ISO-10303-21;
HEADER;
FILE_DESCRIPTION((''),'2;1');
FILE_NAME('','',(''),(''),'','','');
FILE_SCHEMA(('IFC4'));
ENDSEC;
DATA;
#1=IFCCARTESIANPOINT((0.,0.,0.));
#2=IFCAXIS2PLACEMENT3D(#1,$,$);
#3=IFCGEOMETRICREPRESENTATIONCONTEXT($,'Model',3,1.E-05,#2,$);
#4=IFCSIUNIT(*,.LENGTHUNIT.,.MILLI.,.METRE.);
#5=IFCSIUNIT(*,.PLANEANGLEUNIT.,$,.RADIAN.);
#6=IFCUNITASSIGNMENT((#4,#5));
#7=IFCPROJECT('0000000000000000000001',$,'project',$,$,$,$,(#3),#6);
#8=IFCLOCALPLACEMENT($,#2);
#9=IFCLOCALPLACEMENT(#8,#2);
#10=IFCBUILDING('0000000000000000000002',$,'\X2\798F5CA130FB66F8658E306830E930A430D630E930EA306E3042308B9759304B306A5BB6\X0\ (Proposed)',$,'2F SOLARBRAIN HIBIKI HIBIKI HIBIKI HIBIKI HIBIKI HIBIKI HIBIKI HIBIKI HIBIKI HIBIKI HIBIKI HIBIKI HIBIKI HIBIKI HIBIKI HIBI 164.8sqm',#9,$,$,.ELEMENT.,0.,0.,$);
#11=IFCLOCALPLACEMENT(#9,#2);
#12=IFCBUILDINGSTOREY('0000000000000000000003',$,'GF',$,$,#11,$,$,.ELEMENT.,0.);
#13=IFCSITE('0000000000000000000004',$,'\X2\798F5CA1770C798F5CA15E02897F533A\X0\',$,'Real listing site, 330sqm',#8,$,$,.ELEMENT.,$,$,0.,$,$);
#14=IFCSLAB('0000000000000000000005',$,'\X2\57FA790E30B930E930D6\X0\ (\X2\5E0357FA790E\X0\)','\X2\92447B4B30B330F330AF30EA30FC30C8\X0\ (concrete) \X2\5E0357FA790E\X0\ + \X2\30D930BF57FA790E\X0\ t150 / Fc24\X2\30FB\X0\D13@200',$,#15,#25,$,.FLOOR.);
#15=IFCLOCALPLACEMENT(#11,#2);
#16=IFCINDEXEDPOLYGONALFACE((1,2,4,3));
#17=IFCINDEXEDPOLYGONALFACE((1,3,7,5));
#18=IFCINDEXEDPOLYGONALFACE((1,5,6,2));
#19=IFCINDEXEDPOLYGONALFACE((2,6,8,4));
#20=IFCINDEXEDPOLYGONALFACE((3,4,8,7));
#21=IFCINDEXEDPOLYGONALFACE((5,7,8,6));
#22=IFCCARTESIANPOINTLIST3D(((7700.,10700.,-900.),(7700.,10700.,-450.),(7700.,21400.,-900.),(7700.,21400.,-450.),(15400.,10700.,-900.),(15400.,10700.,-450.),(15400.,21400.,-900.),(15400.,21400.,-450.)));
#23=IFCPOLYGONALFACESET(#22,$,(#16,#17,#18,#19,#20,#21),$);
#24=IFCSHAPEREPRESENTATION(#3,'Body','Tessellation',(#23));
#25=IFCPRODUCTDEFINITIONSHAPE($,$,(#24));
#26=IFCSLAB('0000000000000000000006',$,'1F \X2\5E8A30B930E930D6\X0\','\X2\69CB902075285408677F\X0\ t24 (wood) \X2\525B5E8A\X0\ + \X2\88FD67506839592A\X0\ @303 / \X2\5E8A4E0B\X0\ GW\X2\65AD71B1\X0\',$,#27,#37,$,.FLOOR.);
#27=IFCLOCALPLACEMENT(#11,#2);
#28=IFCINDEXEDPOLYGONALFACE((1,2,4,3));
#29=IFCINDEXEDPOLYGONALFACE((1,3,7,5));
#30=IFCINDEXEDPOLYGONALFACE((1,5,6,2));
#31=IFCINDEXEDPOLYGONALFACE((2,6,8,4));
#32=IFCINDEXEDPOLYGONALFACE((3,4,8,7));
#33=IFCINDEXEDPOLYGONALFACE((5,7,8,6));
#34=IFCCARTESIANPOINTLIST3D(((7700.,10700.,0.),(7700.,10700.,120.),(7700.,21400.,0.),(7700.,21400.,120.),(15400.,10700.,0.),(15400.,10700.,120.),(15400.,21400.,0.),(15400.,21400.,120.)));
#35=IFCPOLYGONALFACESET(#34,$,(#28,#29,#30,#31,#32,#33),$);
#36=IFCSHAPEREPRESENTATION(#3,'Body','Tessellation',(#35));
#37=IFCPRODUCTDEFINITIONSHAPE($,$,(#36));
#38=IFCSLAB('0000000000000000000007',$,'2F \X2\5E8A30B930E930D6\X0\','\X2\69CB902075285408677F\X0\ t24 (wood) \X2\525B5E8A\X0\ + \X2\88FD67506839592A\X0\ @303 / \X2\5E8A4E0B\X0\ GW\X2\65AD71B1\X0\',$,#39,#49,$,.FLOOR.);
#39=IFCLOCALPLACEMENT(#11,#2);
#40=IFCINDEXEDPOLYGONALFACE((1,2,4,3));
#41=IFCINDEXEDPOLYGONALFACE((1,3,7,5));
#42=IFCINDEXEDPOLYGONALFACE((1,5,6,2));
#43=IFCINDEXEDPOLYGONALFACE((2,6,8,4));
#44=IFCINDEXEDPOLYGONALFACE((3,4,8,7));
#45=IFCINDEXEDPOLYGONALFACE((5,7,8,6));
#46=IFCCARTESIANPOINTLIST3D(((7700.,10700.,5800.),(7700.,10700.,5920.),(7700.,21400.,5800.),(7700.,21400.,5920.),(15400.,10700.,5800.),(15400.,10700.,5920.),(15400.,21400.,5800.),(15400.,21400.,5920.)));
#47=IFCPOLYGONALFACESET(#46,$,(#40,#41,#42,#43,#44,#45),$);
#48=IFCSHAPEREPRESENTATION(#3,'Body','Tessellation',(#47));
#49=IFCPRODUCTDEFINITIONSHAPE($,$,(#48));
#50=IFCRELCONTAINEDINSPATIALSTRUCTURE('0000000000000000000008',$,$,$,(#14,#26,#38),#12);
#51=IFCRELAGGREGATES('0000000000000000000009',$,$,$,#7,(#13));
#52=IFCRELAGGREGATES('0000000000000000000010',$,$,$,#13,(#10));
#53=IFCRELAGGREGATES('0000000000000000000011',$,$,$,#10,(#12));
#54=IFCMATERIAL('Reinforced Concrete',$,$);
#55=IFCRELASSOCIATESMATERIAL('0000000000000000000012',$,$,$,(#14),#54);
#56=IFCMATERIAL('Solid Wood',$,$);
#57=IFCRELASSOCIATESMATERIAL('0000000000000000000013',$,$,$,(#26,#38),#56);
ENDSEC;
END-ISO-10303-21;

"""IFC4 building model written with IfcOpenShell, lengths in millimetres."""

from ifc_helpers import new_model, si_unit, frame, frame_2d, origin, place, context, project, spatial, rectangle, extrude, material, element, save


model = new_model("IFC4")

# Units and contexts
model_context = context("Model", 3, precision=1e-05, world=origin())
ifc_project = project(units=[si_unit("LENGTHUNIT", "METRE", prefix="MILLI"), si_unit("PLANEANGLEUNIT", "RADIAN")], contexts=[model_context])

# Site, building, storey
site_placement = place(None, origin())
site = spatial("IfcSite", under=ifc_project, at=site_placement, Name="福岡県福岡市西区", ObjectType="Real listing site, 330sqm", CompositionType="ELEMENT", RefElevation=0.0)
building_placement = place(site_placement, origin())
building = spatial("IfcBuilding", under=site, at=building_placement, Name="福岡・書斎とライブラリのある静かな家 (Proposed)", ObjectType="2F SOLARBRAIN HIBIKI HIBIKI HIBIKI HIBIKI HIBIKI HIBIKI HIBIKI HIBIKI HIBIKI HIBIKI HIBIKI HIBIKI HIBIKI HIBIKI HIBIKI HIBI 164.8sqm", CompositionType="ELEMENT", ElevationOfRefHeight=0.0, ElevationOfTerrain=0.0)
storey_placement = place(building_placement, origin())
storey = spatial("IfcBuildingStorey", under=building, at=storey_placement, Name="GF", CompositionType="ELEMENT", Elevation=0.0)

# Shared definitions
ifc_material_1 = material(Name="Solid Wood")

# Slabs
ifc_material_2 = material(Name="Reinforced Concrete")
slab_1_placement = place(storey_placement, frame((3850.0, 5350.0, -450.0)))
element("IfcSlab", 1, at=slab_1_placement, inside=storey, material=ifc_material_2, Name="基礎スラブ (布基礎)", Description="鉄筋コンクリート (concrete) 布基礎 + ベタ基礎 t150 / Fc24・D13@200", PredefinedType="FLOOR", context=model_context, shape_type="SweptSolid", body=[
    extrude(rectangle(XDim=7700.0, YDim=10700.0, at=frame_2d((3850.0, 5350.0))), frame((3850.0, 5350.0, -450.0)), (0.0, 0.0, 1.0), 450.0),
])
slab_2_placement = place(storey_placement, frame((3850.0, 5350.0, 0.0)))
element("IfcSlab", 2, at=slab_2_placement, inside=storey, material=ifc_material_1, Name="1F 床スラブ", Description="構造用合板 t24 (wood) 剛床 + 製材根太 @303 / 床下 GW断熱", PredefinedType="FLOOR", context=model_context, shape_type="SweptSolid", body=[
    extrude(rectangle(XDim=7700.0, YDim=10700.0, at=frame_2d((3850.0, 5350.0))), frame((3850.0, 5350.0, 0.0)), (0.0, 0.0, 1.0), 120.0),
])
slab_3_placement = place(storey_placement, frame((3850.0, 5350.0, 2900.0)))
element("IfcSlab", 3, at=slab_3_placement, inside=storey, material=ifc_material_1, Name="2F 床スラブ", Description="構造用合板 t24 (wood) 剛床 + 製材根太 @303 / 床下 GW断熱", PredefinedType="FLOOR", context=model_context, shape_type="SweptSolid", body=[
    extrude(rectangle(XDim=7700.0, YDim=10700.0, at=frame_2d((3850.0, 5350.0))), frame((3850.0, 5350.0, 2900.0)), (0.0, 0.0, 1.0), 120.0),
])

save(model, "model.ifc")
